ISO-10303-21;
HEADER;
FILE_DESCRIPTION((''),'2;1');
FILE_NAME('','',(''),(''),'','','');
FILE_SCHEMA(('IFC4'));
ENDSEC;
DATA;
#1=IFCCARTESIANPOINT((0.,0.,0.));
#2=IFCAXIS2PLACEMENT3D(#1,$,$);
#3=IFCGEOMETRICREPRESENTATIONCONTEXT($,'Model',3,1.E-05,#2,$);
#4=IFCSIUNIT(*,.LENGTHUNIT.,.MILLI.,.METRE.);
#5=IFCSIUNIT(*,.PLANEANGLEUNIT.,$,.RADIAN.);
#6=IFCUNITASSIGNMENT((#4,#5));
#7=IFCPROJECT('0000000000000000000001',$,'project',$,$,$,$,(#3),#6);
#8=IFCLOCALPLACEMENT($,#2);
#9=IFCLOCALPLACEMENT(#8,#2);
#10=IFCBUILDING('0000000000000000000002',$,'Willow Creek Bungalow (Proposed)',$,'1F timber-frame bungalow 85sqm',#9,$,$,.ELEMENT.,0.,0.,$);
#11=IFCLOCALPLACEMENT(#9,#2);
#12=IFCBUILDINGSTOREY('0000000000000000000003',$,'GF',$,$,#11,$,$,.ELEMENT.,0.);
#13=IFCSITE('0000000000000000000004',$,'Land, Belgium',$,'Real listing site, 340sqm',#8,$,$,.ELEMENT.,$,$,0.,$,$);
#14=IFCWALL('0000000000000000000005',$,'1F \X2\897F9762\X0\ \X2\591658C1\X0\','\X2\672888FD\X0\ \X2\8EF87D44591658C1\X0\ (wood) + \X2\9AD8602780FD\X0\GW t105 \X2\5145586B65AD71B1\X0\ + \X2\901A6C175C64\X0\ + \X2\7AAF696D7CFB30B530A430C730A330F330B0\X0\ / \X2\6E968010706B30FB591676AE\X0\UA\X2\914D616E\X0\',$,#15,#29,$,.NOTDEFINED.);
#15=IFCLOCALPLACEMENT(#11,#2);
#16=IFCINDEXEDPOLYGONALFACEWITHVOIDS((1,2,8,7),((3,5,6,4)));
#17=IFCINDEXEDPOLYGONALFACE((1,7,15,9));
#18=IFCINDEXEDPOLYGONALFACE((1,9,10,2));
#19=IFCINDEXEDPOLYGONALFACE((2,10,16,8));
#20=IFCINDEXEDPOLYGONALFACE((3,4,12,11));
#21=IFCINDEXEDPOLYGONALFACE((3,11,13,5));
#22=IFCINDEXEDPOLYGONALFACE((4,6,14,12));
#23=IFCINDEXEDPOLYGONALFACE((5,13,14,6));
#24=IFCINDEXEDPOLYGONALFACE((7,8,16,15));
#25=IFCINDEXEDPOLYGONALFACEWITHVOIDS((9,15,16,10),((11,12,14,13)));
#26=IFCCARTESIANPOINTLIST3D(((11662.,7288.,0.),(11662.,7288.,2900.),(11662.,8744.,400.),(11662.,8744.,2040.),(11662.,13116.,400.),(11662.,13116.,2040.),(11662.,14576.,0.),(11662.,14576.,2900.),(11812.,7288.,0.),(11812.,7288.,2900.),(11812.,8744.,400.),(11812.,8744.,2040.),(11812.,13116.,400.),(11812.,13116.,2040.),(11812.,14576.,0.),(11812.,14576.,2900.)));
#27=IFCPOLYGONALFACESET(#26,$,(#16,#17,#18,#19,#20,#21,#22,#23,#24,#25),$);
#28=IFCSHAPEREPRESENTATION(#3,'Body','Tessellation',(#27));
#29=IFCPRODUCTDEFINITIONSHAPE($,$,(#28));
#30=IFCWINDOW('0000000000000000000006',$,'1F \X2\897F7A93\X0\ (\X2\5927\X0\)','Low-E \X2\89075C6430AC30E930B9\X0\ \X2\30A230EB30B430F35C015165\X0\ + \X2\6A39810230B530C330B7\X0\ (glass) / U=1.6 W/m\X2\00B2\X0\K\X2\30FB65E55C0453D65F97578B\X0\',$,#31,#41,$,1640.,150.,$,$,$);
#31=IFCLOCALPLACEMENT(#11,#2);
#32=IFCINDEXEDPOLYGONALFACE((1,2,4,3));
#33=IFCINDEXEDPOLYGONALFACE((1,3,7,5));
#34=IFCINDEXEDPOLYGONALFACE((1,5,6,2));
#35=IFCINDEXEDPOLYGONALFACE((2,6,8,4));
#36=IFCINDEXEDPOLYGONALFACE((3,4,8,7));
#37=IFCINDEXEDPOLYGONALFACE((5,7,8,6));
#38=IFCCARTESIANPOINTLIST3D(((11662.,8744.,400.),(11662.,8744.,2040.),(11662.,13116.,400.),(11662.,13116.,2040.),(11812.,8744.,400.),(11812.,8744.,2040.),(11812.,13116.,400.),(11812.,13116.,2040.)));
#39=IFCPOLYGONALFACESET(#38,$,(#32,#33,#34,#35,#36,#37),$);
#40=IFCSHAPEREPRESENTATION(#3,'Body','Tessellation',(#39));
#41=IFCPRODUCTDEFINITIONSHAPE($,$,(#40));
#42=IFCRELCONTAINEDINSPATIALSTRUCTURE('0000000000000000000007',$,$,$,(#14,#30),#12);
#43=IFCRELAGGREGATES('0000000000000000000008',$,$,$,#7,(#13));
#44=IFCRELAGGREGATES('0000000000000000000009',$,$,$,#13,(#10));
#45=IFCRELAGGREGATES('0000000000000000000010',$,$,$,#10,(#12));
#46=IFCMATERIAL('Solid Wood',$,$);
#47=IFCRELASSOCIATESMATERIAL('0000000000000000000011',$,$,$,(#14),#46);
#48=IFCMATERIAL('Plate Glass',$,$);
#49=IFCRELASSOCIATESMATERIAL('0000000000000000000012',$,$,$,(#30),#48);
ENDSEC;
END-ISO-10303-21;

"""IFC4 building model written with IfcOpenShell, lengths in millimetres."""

from ifc_helpers import new_model, si_unit, frame, frame_2d, origin, place, context, project, spatial, rectangle, extrude, material, element, fill, save


model = new_model("IFC4")

# Units and contexts
model_context = context("Model", 3, precision=1e-05, world=origin())
ifc_project = project(units=[si_unit("LENGTHUNIT", "METRE", prefix="MILLI"), si_unit("PLANEANGLEUNIT", "RADIAN")], contexts=[model_context])

# Site, building, storey
site_placement = place(None, origin())
site = spatial("IfcSite", under=ifc_project, at=site_placement, Name="Land, Belgium", ObjectType="Real listing site, 340sqm", CompositionType="ELEMENT", RefElevation=0.0)
building_placement = place(site_placement, origin())
building = spatial("IfcBuilding", under=site, at=building_placement, Name="Willow Creek Bungalow (Proposed)", ObjectType="1F timber-frame bungalow 85sqm", CompositionType="ELEMENT", ElevationOfRefHeight=0.0, ElevationOfTerrain=0.0)
storey_placement = place(building_placement, origin())
storey = spatial("IfcBuildingStorey", under=building, at=storey_placement, Name="GF", CompositionType="ELEMENT", Elevation=0.0)

# Shared definitions
ifc_material_1 = material(Name="Solid Wood")

# Shared definitions
ifc_material_2 = material(Name="Plate Glass")

# Wall, opening, window
wall_1_placement = place(storey_placement, frame((5831.0, 3644.0, 0.0)))
wall_1 = element("IfcWall", 1, at=wall_1_placement, inside=storey, material=ifc_material_1, Name="1F 西面 外壁", Description="木製 軸組外壁 (wood) + 高性能GW t105 充填断熱 + 通気層 + 窯業系サイディング / 準耐火・外皮UA配慮", PredefinedType="NOTDEFINED", context=model_context, shape_type="SweptSolid", body=[
    extrude(rectangle(XDim=150.0, YDim=7288.0, at=frame_2d((75.0, 3644.0))), frame((5831.0, 3644.0, 0.0)), (0.0, 0.0, 1.0), 2900.0),
])
opening_1_placement = place(storey_placement, frame((5831.0, 4372.0, 200.0)))
opening_1 = element("IfcOpeningElement", 2, at=opening_1_placement, cuts=wall_1, PredefinedType="NOTDEFINED", context=model_context, shape_type="SweptSolid", body=[
    extrude(rectangle(XDim=150.0, YDim=4372.0, at=frame_2d((75.0, 2186.0))), frame((5831.0, 4372.0, 200.0)), (0.0, 0.0, 1.0), 1640.0),
])
window_1_placement = place(storey_placement, frame((5831.0, 4372.0, 200.0)))
window_1 = element("IfcWindow", 3, at=window_1_placement, inside=storey, material=ifc_material_2, Name="1F 西窓 (大)", Description="Low-E 複層ガラス アルゴン封入 + 樹脂サッシ (glass) / U=1.6 W/m²K・日射取得型", OverallHeight=1640.0, OverallWidth=150.0, context=model_context, shape_type="SweptSolid", body=[
    extrude(rectangle(XDim=150.0, YDim=4372.0, at=frame_2d((75.0, 2186.0))), frame((5831.0, 4372.0, 200.0)), (0.0, 0.0, 1.0), 1640.0),
])
fill(opening_1, window_1)

save(model, "model.ifc")
